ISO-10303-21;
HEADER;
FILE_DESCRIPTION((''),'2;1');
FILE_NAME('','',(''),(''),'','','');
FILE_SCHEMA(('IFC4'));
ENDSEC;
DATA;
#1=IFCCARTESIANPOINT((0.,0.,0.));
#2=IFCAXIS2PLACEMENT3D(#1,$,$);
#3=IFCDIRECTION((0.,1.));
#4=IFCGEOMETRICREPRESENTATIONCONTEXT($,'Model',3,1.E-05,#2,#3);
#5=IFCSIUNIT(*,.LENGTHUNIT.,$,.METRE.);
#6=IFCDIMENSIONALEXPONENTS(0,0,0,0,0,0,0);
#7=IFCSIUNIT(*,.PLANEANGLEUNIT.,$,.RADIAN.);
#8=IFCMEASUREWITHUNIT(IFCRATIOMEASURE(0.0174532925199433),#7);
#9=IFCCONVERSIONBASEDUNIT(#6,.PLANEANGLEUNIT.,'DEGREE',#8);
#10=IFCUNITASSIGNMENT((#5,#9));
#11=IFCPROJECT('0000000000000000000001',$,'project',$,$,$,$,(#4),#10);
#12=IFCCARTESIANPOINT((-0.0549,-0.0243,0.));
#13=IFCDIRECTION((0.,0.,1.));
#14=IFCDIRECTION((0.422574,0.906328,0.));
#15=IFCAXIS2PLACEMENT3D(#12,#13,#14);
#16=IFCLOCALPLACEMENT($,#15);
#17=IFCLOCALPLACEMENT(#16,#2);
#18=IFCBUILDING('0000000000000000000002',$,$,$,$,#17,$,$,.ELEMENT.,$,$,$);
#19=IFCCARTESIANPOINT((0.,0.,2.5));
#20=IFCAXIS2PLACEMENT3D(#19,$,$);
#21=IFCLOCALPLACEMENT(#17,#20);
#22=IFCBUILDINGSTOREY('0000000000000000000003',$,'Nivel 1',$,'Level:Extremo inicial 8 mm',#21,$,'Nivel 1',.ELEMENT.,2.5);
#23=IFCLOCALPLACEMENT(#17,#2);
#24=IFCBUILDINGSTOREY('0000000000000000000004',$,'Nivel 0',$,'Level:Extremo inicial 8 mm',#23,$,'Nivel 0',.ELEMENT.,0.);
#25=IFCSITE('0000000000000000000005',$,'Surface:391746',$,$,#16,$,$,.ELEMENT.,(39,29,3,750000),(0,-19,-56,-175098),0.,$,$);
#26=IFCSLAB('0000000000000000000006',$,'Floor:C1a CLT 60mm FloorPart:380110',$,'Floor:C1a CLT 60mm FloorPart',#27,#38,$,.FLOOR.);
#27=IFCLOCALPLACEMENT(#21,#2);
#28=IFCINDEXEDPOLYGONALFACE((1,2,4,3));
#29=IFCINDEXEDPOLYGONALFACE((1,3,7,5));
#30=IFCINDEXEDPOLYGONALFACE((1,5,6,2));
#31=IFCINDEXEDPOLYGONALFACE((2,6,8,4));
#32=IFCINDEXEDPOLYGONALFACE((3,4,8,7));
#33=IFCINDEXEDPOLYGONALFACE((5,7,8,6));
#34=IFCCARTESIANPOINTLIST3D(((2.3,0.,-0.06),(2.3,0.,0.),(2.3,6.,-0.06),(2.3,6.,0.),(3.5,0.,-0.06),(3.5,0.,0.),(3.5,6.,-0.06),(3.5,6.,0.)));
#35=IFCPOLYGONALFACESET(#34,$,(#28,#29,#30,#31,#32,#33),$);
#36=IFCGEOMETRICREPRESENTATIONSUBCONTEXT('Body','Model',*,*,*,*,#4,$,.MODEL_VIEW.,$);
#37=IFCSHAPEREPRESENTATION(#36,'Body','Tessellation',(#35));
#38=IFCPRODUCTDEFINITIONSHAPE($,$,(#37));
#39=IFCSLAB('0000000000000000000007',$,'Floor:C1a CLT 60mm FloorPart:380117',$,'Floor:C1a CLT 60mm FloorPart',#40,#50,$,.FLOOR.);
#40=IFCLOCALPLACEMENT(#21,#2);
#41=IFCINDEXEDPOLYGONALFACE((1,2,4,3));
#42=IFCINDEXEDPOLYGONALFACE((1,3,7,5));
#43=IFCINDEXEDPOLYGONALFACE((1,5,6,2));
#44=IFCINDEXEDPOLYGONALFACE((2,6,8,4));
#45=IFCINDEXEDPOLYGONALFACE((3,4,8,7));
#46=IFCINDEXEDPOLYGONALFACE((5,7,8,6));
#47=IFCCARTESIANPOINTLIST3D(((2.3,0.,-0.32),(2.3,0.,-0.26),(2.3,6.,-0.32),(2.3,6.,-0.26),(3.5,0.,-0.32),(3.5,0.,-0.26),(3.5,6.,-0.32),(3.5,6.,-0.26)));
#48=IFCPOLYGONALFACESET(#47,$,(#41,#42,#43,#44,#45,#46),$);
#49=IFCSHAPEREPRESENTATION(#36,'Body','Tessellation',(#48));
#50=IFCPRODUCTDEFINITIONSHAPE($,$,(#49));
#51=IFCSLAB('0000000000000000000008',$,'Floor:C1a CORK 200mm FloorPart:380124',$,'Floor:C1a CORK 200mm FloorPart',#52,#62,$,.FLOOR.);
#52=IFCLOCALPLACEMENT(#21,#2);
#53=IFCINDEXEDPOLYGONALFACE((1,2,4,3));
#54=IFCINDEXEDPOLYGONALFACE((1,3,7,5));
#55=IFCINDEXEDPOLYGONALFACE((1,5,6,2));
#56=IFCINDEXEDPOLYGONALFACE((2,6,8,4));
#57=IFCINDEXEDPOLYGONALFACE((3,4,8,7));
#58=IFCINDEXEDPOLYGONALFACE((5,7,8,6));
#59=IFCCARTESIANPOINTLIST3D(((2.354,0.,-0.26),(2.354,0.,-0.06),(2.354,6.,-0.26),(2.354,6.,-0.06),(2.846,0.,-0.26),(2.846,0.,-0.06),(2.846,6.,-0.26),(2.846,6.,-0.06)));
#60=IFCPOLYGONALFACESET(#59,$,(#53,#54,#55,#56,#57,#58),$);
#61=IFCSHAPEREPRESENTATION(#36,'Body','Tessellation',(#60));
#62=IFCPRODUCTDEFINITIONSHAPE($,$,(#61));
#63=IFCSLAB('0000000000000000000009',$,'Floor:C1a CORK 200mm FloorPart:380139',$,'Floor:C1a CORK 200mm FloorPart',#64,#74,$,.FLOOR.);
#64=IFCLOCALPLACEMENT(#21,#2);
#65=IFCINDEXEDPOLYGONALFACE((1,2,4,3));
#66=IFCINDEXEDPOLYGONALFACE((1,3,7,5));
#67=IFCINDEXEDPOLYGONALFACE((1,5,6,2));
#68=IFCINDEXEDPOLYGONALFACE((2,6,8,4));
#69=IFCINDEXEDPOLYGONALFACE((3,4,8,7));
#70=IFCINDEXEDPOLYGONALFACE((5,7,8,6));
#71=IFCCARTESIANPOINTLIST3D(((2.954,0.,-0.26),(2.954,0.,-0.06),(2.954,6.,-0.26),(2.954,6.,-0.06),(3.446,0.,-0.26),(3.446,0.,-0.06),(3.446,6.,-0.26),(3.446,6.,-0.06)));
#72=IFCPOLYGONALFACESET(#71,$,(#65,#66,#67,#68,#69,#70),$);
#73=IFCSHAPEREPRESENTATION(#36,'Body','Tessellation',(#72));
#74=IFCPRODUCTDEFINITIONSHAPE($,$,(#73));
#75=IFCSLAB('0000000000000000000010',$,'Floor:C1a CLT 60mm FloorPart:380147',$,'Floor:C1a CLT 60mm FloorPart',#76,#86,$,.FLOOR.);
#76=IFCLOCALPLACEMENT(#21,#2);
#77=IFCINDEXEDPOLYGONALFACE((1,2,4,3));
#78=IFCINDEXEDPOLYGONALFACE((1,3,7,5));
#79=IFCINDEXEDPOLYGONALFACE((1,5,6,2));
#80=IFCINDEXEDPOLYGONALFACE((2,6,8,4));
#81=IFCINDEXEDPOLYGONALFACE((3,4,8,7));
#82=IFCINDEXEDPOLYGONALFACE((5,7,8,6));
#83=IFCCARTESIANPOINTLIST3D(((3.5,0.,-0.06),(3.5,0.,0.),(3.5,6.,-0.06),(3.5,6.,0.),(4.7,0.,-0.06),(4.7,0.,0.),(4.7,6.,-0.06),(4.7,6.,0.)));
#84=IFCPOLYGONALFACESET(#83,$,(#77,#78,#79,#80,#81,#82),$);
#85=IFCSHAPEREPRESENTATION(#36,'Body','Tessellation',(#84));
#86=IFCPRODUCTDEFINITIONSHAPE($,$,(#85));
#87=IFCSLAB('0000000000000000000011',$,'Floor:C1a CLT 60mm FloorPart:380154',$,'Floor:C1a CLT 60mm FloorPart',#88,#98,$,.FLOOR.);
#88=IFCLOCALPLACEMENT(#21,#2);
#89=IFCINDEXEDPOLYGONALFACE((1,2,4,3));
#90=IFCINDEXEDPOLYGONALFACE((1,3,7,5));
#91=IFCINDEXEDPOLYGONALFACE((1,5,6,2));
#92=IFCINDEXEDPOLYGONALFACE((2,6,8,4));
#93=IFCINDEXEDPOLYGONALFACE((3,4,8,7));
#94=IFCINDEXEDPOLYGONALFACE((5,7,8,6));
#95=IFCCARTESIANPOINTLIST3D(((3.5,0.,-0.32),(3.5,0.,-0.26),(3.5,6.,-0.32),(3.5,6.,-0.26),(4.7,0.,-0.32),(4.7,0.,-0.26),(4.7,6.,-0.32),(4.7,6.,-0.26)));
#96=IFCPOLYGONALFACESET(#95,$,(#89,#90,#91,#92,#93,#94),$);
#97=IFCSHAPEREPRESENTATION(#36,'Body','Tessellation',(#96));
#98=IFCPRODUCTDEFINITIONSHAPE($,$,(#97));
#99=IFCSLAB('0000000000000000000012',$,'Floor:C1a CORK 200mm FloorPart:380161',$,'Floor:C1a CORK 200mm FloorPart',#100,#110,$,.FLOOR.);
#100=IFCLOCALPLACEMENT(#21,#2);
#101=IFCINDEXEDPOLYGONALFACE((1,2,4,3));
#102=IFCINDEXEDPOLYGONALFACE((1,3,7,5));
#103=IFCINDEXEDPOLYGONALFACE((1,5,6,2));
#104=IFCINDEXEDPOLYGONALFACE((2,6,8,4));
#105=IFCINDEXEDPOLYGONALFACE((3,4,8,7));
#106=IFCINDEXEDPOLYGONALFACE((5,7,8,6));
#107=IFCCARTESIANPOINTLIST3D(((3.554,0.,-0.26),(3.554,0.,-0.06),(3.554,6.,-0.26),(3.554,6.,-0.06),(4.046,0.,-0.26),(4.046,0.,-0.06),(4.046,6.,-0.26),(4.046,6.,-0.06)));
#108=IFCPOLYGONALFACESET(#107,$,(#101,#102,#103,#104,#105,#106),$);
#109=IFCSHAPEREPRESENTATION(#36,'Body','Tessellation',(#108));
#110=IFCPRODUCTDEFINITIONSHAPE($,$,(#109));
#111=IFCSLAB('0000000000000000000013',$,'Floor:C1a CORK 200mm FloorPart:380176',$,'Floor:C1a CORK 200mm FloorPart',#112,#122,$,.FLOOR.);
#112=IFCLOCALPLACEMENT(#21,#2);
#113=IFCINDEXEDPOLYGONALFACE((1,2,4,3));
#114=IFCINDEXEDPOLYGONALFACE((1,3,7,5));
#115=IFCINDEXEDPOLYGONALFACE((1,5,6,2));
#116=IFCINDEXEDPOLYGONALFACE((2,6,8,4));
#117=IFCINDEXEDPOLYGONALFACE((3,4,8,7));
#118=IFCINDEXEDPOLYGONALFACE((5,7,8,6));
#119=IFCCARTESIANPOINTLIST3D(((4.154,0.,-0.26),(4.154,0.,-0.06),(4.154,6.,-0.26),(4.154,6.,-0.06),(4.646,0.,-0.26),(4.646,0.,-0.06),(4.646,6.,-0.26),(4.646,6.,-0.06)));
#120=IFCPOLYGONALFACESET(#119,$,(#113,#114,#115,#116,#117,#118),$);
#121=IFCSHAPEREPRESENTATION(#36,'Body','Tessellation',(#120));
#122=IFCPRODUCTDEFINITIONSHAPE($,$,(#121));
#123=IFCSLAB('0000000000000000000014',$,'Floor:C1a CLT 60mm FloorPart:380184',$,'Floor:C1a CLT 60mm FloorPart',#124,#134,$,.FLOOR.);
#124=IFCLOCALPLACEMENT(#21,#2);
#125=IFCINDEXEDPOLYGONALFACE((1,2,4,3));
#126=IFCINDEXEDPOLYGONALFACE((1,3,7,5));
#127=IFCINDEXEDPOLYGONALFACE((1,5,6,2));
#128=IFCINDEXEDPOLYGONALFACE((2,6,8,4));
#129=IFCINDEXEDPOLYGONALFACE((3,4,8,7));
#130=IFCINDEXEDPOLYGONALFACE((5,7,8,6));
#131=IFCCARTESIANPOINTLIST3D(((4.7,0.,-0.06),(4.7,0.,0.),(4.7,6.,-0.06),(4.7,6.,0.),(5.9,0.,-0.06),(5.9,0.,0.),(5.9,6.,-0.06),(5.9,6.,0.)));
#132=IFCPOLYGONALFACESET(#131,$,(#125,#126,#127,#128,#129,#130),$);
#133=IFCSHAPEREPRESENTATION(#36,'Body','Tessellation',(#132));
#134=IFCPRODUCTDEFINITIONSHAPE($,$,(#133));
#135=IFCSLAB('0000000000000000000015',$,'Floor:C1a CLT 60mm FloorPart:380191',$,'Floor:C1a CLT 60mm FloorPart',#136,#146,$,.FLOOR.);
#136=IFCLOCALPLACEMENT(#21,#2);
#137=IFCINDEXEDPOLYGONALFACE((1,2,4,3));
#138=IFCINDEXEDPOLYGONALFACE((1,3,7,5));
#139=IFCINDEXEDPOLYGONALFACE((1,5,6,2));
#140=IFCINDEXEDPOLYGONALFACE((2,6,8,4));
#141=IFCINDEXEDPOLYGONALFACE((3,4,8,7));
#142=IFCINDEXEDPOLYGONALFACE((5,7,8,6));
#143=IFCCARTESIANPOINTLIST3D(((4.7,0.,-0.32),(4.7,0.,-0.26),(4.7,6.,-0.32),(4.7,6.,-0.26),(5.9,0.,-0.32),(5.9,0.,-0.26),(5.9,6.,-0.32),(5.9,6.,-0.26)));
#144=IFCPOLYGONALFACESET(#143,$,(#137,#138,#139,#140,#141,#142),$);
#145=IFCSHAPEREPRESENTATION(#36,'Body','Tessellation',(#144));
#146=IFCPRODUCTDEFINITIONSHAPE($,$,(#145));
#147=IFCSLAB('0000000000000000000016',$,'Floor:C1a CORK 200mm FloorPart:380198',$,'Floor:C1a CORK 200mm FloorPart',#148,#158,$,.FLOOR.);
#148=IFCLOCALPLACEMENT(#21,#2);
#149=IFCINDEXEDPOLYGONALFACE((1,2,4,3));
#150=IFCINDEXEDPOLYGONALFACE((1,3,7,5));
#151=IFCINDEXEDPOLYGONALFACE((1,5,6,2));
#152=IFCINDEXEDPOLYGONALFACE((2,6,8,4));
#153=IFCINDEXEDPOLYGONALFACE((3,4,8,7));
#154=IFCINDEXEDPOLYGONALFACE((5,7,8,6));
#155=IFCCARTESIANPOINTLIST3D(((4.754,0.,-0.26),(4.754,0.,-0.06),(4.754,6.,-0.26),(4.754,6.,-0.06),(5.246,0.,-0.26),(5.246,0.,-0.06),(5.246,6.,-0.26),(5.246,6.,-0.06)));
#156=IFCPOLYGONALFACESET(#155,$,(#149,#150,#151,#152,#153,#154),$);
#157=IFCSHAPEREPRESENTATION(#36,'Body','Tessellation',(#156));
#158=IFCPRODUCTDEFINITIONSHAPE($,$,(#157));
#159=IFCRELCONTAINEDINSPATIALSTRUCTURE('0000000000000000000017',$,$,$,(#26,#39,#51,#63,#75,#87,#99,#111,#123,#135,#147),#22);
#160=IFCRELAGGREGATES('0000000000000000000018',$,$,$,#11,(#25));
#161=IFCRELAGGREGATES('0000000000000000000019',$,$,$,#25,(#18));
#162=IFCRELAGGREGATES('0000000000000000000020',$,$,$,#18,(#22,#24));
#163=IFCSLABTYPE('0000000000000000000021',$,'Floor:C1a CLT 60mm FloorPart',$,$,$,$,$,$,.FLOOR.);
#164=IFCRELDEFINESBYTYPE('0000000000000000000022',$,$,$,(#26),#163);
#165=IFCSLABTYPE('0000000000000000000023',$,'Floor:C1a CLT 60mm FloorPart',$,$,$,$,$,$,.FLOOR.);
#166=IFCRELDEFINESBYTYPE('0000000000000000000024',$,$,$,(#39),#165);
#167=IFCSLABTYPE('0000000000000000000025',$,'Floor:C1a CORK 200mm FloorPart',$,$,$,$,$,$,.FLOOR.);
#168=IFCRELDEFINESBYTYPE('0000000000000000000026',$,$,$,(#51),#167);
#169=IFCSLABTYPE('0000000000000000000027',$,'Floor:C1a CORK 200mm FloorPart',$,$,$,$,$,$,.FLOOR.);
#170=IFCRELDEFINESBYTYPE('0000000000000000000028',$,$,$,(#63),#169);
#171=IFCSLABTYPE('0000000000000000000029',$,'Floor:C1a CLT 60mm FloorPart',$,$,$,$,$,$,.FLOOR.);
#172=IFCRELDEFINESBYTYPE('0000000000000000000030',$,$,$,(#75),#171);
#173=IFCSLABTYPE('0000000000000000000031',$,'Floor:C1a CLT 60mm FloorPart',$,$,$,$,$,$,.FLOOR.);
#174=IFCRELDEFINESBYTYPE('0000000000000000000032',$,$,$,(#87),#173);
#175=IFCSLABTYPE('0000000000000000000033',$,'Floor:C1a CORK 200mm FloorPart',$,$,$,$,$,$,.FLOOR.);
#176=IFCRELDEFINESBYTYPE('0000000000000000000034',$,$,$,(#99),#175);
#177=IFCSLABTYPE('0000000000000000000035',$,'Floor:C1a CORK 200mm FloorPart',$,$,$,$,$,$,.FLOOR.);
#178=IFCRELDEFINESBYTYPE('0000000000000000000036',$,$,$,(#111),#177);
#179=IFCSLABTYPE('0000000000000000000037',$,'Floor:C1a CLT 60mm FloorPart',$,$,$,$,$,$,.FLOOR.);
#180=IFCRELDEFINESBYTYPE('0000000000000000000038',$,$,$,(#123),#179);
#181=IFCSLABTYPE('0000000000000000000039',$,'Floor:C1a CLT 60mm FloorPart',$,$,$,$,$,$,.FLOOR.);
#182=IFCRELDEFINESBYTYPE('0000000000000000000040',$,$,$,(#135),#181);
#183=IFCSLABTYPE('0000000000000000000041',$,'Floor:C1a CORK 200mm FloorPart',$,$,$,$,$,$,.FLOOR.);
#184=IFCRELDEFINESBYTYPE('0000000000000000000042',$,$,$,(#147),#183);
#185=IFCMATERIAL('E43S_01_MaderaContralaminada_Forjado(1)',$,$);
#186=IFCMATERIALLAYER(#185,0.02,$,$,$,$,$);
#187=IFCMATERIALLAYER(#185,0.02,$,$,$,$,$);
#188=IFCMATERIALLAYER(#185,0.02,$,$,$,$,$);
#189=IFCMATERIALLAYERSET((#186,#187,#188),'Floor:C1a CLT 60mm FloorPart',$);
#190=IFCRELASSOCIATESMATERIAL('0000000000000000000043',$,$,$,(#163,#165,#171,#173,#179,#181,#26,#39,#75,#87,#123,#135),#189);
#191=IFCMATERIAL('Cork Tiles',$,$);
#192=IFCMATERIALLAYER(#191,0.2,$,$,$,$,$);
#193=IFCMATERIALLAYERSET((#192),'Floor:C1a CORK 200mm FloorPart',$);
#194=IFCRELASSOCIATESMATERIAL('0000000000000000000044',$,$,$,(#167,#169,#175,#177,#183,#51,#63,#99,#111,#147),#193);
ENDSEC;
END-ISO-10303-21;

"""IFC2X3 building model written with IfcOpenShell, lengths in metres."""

from ifc_helpers import new_model, entity, si_unit, converted_unit, direction, frame, frame_2d, origin, origin_2d_with_axis, place, context, subcontext, project, spatial, rectangle, extrude, material, layer, layer_set, layer_usage, type_object, element, save


model = new_model("IFC2X3")

# Units and contexts
model_context = context("Model", 3, precision=1e-05, world=origin(), true_north=direction((0.0, 1.0)))
body_context = subcontext(model_context, "Body", "Model", "MODEL_VIEW")
ifc_project = project(units=[si_unit("LENGTHUNIT", "METRE"), converted_unit("PLANEANGLEUNIT", "DEGREE", entity("IfcRatioMeasure", 0.0174532925199433), si_unit("PLANEANGLEUNIT", "RADIAN"), dimensions=[0, 0, 0, 0, 0, 0, 0])], contexts=[model_context])

# Site, building, storey
site_placement = place(None, frame((-0.0549, -0.0243, 0.0), z_axis=(0.0, 0.0, 1.0), x_axis=(0.422574, 0.906328, 0.0)))
site = spatial("IfcSite", under=ifc_project, at=site_placement, Name="Surface:391746", CompositionType="ELEMENT", RefLatitude=(39, 29, 3, 750000), RefLongitude=(0, -19, -56, -175098), RefElevation=0.0)
building_placement = place(site_placement, origin())
building = spatial("IfcBuilding", under=site, at=building_placement, CompositionType="ELEMENT")
storey_1_placement = place(building_placement, frame((0.0, 0.0, 2.5)))
storey_1 = spatial("IfcBuildingStorey", under=building, at=storey_1_placement, Name="Nivel 1", ObjectType="Level:Extremo inicial 8 mm", LongName="Nivel 1", CompositionType="ELEMENT", Elevation=2.5)

# Shared definitions
ifc_material_1 = material(Name="E43S_01_MaderaContralaminada_Forjado(1)")

# Slabs
ifc_layer_1 = layer(ifc_material_1, 0.02)
ifc_layer_2 = layer(ifc_material_1, 0.02)
ifc_layer_3 = layer(ifc_material_1, 0.02)
ifc_layer_set_1 = layer_set([ifc_layer_1, ifc_layer_2, ifc_layer_3], Name="Floor:C1a CLT 60mm FloorPart")
ifc_layer_usage_1 = layer_usage(ifc_layer_set_1, "AXIS3", "POSITIVE", 0.0)
slab_type_1 = type_object("IfcSlabType", Name="Floor:C1a CLT 60mm FloorPart", PredefinedType="FLOOR", material=ifc_layer_set_1)
slab_1_placement = place(storey_1_placement, origin())
element("IfcSlab", 1, at=slab_1_placement, inside=storey_1, type_object=slab_type_1, material=ifc_layer_usage_1, Name="Floor:C1a CLT 60mm FloorPart:380110", ObjectType="Floor:C1a CLT 60mm FloorPart", PredefinedType="FLOOR", context=body_context, shape_type="SweptSolid", body=[
    extrude(rectangle(XDim=6.0, YDim=1.2, at=frame_2d((0.0, 0.0), x_axis=(1.0, 0.0))), frame((2.9, 3.0, 0.0), z_axis=(0.0, 0.0, -1.0), x_axis=(0.0, 1.0, 0.0)), (0.0, 0.0, 1.0), 0.06),
])
ifc_layer_usage_2 = layer_usage(ifc_layer_set_1, "AXIS3", "POSITIVE", 0.0)
slab_type_2 = type_object("IfcSlabType", Name="Floor:C1a CLT 60mm FloorPart", PredefinedType="FLOOR", material=ifc_layer_set_1)
slab_2_placement = place(storey_1_placement, origin())
element("IfcSlab", 2, at=slab_2_placement, inside=storey_1, type_object=slab_type_2, material=ifc_layer_usage_2, Name="Floor:C1a CLT 60mm FloorPart:380117", ObjectType="Floor:C1a CLT 60mm FloorPart", PredefinedType="FLOOR", context=body_context, shape_type="SweptSolid", body=[
    extrude(rectangle(XDim=6.0, YDim=1.2, at=frame_2d((0.0, 0.0), x_axis=(1.0, 0.0))), frame((2.9, 3.0, -0.26), z_axis=(0.0, 0.0, -1.0), x_axis=(0.0, 1.0, 0.0)), (0.0, 0.0, 1.0), 0.06),
])
ifc_material_2 = material(Name="Cork Tiles")
ifc_layer_4 = layer(ifc_material_2, 0.2)
ifc_layer_set_2 = layer_set([ifc_layer_4], Name="Floor:C1a CORK 200mm FloorPart")
ifc_layer_usage_3 = layer_usage(ifc_layer_set_2, "AXIS3", "POSITIVE", 0.0)
slab_type_3 = type_object("IfcSlabType", Name="Floor:C1a CORK 200mm FloorPart", PredefinedType="FLOOR", material=ifc_layer_set_2)
slab_3_placement = place(storey_1_placement, origin())
element("IfcSlab", 3, at=slab_3_placement, inside=storey_1, type_object=slab_type_3, material=ifc_layer_usage_3, Name="Floor:C1a CORK 200mm FloorPart:380124", ObjectType="Floor:C1a CORK 200mm FloorPart", PredefinedType="FLOOR", context=body_context, shape_type="SweptSolid", body=[
    extrude(rectangle(XDim=6.0, YDim=0.492, at=frame_2d((0.0, 0.0), x_axis=(1.0, 0.0))), frame((2.6, 3.0, -0.06), z_axis=(0.0, 0.0, -1.0), x_axis=(0.0, 1.0, 0.0)), (0.0, 0.0, 1.0), 0.2),
])
ifc_layer_usage_4 = layer_usage(ifc_layer_set_2, "AXIS3", "POSITIVE", 0.0)
slab_type_4 = type_object("IfcSlabType", Name="Floor:C1a CORK 200mm FloorPart", PredefinedType="FLOOR", material=ifc_layer_set_2)
slab_4_placement = place(storey_1_placement, origin())
element("IfcSlab", 4, at=slab_4_placement, inside=storey_1, type_object=slab_type_4, material=ifc_layer_usage_4, Name="Floor:C1a CORK 200mm FloorPart:380139", ObjectType="Floor:C1a CORK 200mm FloorPart", PredefinedType="FLOOR", context=body_context, shape_type="SweptSolid", body=[
    extrude(rectangle(XDim=6.0, YDim=0.492, at=frame_2d((0.0, 0.0), x_axis=(1.0, 0.0))), frame((3.2, 3.0, -0.06), z_axis=(0.0, 0.0, -1.0), x_axis=(0.0, 1.0, 0.0)), (0.0, 0.0, 1.0), 0.2),
])
ifc_layer_usage_5 = layer_usage(ifc_layer_set_1, "AXIS3", "POSITIVE", 0.0)
slab_type_5 = type_object("IfcSlabType", Name="Floor:C1a CLT 60mm FloorPart", PredefinedType="FLOOR", material=ifc_layer_set_1)
slab_5_placement = place(storey_1_placement, origin())
element("IfcSlab", 5, at=slab_5_placement, inside=storey_1, type_object=slab_type_5, material=ifc_layer_usage_5, Name="Floor:C1a CLT 60mm FloorPart:380147", ObjectType="Floor:C1a CLT 60mm FloorPart", PredefinedType="FLOOR", context=body_context, shape_type="SweptSolid", body=[
    extrude(rectangle(XDim=6.0, YDim=1.2, at=frame_2d((0.0, 0.0), x_axis=(1.0, 0.0))), frame((4.1, 3.0, 0.0), z_axis=(0.0, 0.0, -1.0), x_axis=(0.0, 1.0, 0.0)), (0.0, 0.0, 1.0), 0.06),
])
ifc_layer_usage_6 = layer_usage(ifc_layer_set_1, "AXIS3", "POSITIVE", 0.0)
slab_type_6 = type_object("IfcSlabType", Name="Floor:C1a CLT 60mm FloorPart", PredefinedType="FLOOR", material=ifc_layer_set_1)
slab_6_placement = place(storey_1_placement, origin())
element("IfcSlab", 6, at=slab_6_placement, inside=storey_1, type_object=slab_type_6, material=ifc_layer_usage_6, Name="Floor:C1a CLT 60mm FloorPart:380154", ObjectType="Floor:C1a CLT 60mm FloorPart", PredefinedType="FLOOR", context=body_context, shape_type="SweptSolid", body=[
    extrude(rectangle(XDim=6.0, YDim=1.2, at=frame_2d((0.0, 0.0), x_axis=(1.0, 0.0))), frame((4.1, 3.0, -0.26), z_axis=(0.0, 0.0, -1.0), x_axis=(0.0, 1.0, 0.0)), (0.0, 0.0, 1.0), 0.06),
])
ifc_layer_usage_7 = layer_usage(ifc_layer_set_2, "AXIS3", "POSITIVE", 0.0)
slab_type_7 = type_object("IfcSlabType", Name="Floor:C1a CORK 200mm FloorPart", PredefinedType="FLOOR", material=ifc_layer_set_2)
slab_7_placement = place(storey_1_placement, origin())
element("IfcSlab", 7, at=slab_7_placement, inside=storey_1, type_object=slab_type_7, material=ifc_layer_usage_7, Name="Floor:C1a CORK 200mm FloorPart:380161", ObjectType="Floor:C1a CORK 200mm FloorPart", PredefinedType="FLOOR", context=body_context, shape_type="SweptSolid", body=[
    extrude(rectangle(XDim=6.0, YDim=0.492, at=frame_2d((0.0, 0.0), x_axis=(1.0, 0.0))), frame((3.8, 3.0, -0.06), z_axis=(0.0, 0.0, -1.0), x_axis=(0.0, 1.0, 0.0)), (0.0, 0.0, 1.0), 0.2),
])
ifc_layer_usage_8 = layer_usage(ifc_layer_set_2, "AXIS3", "POSITIVE", 0.0)
slab_type_8 = type_object("IfcSlabType", Name="Floor:C1a CORK 200mm FloorPart", PredefinedType="FLOOR", material=ifc_layer_set_2)
slab_8_placement = place(storey_1_placement, origin())
element("IfcSlab", 8, at=slab_8_placement, inside=storey_1, type_object=slab_type_8, material=ifc_layer_usage_8, Name="Floor:C1a CORK 200mm FloorPart:380176", ObjectType="Floor:C1a CORK 200mm FloorPart", PredefinedType="FLOOR", context=body_context, shape_type="SweptSolid", body=[
    extrude(rectangle(XDim=6.0, YDim=0.492, at=frame_2d((0.0, 0.0), x_axis=(1.0, 0.0))), frame((4.4, 3.0, -0.06), z_axis=(0.0, 0.0, -1.0), x_axis=(0.0, 1.0, 0.0)), (0.0, 0.0, 1.0), 0.2),
])
ifc_layer_usage_9 = layer_usage(ifc_layer_set_1, "AXIS3", "POSITIVE", 0.0)
slab_type_9 = type_object("IfcSlabType", Name="Floor:C1a CLT 60mm FloorPart", PredefinedType="FLOOR", material=ifc_layer_set_1)
slab_9_placement = place(storey_1_placement, origin())
element("IfcSlab", 9, at=slab_9_placement, inside=storey_1, type_object=slab_type_9, material=ifc_layer_usage_9, Name="Floor:C1a CLT 60mm FloorPart:380184", ObjectType="Floor:C1a CLT 60mm FloorPart", PredefinedType="FLOOR", context=body_context, shape_type="SweptSolid", body=[
    extrude(rectangle(XDim=6.0, YDim=1.2, at=frame_2d((0.0, 0.0), x_axis=(1.0, 0.0))), frame((5.3, 3.0, 0.0), z_axis=(0.0, 0.0, -1.0), x_axis=(0.0, 1.0, 0.0)), (0.0, 0.0, 1.0), 0.06),
])
ifc_layer_usage_10 = layer_usage(ifc_layer_set_1, "AXIS3", "POSITIVE", 0.0)
slab_type_10 = type_object("IfcSlabType", Name="Floor:C1a CLT 60mm FloorPart", PredefinedType="FLOOR", material=ifc_layer_set_1)
slab_10_placement = place(storey_1_placement, origin())
element("IfcSlab", 10, at=slab_10_placement, inside=storey_1, type_object=slab_type_10, material=ifc_layer_usage_10, Name="Floor:C1a CLT 60mm FloorPart:380191", ObjectType="Floor:C1a CLT 60mm FloorPart", PredefinedType="FLOOR", context=body_context, shape_type="SweptSolid", body=[
    extrude(rectangle(XDim=6.0, YDim=1.2, at=frame_2d((0.0, 0.0), x_axis=(1.0, 0.0))), frame((5.3, 3.0, -0.26), z_axis=(0.0, 0.0, -1.0), x_axis=(0.0, 1.0, 0.0)), (0.0, 0.0, 1.0), 0.06),
])
ifc_layer_usage_11 = layer_usage(ifc_layer_set_2, "AXIS3", "POSITIVE", 0.0)
slab_type_11 = type_object("IfcSlabType", Name="Floor:C1a CORK 200mm FloorPart", PredefinedType="FLOOR", material=ifc_layer_set_2)
slab_11_placement = place(storey_1_placement, origin())
element("IfcSlab", 11, at=slab_11_placement, inside=storey_1, type_object=slab_type_11, material=ifc_layer_usage_11, Name="Floor:C1a CORK 200mm FloorPart:380198", ObjectType="Floor:C1a CORK 200mm FloorPart", PredefinedType="FLOOR", context=body_context, shape_type="SweptSolid", body=[
    extrude(rectangle(XDim=6.0, YDim=0.492, at=origin_2d_with_axis()), frame((5.0, 3.0, -0.06), z_axis=(0.0, 0.0, -1.0), x_axis=(0.0, 1.0, 0.0)), (0.0, 0.0, 1.0), 0.2),
])

# Shared definitions
storey_2_placement = place(building_placement, origin())
storey_2 = spatial("IfcBuildingStorey", under=building, at=storey_2_placement, Name="Nivel 0", ObjectType="Level:Extremo inicial 8 mm", LongName="Nivel 0", CompositionType="ELEMENT", Elevation=0.0)

save(model, "model.ifc")
